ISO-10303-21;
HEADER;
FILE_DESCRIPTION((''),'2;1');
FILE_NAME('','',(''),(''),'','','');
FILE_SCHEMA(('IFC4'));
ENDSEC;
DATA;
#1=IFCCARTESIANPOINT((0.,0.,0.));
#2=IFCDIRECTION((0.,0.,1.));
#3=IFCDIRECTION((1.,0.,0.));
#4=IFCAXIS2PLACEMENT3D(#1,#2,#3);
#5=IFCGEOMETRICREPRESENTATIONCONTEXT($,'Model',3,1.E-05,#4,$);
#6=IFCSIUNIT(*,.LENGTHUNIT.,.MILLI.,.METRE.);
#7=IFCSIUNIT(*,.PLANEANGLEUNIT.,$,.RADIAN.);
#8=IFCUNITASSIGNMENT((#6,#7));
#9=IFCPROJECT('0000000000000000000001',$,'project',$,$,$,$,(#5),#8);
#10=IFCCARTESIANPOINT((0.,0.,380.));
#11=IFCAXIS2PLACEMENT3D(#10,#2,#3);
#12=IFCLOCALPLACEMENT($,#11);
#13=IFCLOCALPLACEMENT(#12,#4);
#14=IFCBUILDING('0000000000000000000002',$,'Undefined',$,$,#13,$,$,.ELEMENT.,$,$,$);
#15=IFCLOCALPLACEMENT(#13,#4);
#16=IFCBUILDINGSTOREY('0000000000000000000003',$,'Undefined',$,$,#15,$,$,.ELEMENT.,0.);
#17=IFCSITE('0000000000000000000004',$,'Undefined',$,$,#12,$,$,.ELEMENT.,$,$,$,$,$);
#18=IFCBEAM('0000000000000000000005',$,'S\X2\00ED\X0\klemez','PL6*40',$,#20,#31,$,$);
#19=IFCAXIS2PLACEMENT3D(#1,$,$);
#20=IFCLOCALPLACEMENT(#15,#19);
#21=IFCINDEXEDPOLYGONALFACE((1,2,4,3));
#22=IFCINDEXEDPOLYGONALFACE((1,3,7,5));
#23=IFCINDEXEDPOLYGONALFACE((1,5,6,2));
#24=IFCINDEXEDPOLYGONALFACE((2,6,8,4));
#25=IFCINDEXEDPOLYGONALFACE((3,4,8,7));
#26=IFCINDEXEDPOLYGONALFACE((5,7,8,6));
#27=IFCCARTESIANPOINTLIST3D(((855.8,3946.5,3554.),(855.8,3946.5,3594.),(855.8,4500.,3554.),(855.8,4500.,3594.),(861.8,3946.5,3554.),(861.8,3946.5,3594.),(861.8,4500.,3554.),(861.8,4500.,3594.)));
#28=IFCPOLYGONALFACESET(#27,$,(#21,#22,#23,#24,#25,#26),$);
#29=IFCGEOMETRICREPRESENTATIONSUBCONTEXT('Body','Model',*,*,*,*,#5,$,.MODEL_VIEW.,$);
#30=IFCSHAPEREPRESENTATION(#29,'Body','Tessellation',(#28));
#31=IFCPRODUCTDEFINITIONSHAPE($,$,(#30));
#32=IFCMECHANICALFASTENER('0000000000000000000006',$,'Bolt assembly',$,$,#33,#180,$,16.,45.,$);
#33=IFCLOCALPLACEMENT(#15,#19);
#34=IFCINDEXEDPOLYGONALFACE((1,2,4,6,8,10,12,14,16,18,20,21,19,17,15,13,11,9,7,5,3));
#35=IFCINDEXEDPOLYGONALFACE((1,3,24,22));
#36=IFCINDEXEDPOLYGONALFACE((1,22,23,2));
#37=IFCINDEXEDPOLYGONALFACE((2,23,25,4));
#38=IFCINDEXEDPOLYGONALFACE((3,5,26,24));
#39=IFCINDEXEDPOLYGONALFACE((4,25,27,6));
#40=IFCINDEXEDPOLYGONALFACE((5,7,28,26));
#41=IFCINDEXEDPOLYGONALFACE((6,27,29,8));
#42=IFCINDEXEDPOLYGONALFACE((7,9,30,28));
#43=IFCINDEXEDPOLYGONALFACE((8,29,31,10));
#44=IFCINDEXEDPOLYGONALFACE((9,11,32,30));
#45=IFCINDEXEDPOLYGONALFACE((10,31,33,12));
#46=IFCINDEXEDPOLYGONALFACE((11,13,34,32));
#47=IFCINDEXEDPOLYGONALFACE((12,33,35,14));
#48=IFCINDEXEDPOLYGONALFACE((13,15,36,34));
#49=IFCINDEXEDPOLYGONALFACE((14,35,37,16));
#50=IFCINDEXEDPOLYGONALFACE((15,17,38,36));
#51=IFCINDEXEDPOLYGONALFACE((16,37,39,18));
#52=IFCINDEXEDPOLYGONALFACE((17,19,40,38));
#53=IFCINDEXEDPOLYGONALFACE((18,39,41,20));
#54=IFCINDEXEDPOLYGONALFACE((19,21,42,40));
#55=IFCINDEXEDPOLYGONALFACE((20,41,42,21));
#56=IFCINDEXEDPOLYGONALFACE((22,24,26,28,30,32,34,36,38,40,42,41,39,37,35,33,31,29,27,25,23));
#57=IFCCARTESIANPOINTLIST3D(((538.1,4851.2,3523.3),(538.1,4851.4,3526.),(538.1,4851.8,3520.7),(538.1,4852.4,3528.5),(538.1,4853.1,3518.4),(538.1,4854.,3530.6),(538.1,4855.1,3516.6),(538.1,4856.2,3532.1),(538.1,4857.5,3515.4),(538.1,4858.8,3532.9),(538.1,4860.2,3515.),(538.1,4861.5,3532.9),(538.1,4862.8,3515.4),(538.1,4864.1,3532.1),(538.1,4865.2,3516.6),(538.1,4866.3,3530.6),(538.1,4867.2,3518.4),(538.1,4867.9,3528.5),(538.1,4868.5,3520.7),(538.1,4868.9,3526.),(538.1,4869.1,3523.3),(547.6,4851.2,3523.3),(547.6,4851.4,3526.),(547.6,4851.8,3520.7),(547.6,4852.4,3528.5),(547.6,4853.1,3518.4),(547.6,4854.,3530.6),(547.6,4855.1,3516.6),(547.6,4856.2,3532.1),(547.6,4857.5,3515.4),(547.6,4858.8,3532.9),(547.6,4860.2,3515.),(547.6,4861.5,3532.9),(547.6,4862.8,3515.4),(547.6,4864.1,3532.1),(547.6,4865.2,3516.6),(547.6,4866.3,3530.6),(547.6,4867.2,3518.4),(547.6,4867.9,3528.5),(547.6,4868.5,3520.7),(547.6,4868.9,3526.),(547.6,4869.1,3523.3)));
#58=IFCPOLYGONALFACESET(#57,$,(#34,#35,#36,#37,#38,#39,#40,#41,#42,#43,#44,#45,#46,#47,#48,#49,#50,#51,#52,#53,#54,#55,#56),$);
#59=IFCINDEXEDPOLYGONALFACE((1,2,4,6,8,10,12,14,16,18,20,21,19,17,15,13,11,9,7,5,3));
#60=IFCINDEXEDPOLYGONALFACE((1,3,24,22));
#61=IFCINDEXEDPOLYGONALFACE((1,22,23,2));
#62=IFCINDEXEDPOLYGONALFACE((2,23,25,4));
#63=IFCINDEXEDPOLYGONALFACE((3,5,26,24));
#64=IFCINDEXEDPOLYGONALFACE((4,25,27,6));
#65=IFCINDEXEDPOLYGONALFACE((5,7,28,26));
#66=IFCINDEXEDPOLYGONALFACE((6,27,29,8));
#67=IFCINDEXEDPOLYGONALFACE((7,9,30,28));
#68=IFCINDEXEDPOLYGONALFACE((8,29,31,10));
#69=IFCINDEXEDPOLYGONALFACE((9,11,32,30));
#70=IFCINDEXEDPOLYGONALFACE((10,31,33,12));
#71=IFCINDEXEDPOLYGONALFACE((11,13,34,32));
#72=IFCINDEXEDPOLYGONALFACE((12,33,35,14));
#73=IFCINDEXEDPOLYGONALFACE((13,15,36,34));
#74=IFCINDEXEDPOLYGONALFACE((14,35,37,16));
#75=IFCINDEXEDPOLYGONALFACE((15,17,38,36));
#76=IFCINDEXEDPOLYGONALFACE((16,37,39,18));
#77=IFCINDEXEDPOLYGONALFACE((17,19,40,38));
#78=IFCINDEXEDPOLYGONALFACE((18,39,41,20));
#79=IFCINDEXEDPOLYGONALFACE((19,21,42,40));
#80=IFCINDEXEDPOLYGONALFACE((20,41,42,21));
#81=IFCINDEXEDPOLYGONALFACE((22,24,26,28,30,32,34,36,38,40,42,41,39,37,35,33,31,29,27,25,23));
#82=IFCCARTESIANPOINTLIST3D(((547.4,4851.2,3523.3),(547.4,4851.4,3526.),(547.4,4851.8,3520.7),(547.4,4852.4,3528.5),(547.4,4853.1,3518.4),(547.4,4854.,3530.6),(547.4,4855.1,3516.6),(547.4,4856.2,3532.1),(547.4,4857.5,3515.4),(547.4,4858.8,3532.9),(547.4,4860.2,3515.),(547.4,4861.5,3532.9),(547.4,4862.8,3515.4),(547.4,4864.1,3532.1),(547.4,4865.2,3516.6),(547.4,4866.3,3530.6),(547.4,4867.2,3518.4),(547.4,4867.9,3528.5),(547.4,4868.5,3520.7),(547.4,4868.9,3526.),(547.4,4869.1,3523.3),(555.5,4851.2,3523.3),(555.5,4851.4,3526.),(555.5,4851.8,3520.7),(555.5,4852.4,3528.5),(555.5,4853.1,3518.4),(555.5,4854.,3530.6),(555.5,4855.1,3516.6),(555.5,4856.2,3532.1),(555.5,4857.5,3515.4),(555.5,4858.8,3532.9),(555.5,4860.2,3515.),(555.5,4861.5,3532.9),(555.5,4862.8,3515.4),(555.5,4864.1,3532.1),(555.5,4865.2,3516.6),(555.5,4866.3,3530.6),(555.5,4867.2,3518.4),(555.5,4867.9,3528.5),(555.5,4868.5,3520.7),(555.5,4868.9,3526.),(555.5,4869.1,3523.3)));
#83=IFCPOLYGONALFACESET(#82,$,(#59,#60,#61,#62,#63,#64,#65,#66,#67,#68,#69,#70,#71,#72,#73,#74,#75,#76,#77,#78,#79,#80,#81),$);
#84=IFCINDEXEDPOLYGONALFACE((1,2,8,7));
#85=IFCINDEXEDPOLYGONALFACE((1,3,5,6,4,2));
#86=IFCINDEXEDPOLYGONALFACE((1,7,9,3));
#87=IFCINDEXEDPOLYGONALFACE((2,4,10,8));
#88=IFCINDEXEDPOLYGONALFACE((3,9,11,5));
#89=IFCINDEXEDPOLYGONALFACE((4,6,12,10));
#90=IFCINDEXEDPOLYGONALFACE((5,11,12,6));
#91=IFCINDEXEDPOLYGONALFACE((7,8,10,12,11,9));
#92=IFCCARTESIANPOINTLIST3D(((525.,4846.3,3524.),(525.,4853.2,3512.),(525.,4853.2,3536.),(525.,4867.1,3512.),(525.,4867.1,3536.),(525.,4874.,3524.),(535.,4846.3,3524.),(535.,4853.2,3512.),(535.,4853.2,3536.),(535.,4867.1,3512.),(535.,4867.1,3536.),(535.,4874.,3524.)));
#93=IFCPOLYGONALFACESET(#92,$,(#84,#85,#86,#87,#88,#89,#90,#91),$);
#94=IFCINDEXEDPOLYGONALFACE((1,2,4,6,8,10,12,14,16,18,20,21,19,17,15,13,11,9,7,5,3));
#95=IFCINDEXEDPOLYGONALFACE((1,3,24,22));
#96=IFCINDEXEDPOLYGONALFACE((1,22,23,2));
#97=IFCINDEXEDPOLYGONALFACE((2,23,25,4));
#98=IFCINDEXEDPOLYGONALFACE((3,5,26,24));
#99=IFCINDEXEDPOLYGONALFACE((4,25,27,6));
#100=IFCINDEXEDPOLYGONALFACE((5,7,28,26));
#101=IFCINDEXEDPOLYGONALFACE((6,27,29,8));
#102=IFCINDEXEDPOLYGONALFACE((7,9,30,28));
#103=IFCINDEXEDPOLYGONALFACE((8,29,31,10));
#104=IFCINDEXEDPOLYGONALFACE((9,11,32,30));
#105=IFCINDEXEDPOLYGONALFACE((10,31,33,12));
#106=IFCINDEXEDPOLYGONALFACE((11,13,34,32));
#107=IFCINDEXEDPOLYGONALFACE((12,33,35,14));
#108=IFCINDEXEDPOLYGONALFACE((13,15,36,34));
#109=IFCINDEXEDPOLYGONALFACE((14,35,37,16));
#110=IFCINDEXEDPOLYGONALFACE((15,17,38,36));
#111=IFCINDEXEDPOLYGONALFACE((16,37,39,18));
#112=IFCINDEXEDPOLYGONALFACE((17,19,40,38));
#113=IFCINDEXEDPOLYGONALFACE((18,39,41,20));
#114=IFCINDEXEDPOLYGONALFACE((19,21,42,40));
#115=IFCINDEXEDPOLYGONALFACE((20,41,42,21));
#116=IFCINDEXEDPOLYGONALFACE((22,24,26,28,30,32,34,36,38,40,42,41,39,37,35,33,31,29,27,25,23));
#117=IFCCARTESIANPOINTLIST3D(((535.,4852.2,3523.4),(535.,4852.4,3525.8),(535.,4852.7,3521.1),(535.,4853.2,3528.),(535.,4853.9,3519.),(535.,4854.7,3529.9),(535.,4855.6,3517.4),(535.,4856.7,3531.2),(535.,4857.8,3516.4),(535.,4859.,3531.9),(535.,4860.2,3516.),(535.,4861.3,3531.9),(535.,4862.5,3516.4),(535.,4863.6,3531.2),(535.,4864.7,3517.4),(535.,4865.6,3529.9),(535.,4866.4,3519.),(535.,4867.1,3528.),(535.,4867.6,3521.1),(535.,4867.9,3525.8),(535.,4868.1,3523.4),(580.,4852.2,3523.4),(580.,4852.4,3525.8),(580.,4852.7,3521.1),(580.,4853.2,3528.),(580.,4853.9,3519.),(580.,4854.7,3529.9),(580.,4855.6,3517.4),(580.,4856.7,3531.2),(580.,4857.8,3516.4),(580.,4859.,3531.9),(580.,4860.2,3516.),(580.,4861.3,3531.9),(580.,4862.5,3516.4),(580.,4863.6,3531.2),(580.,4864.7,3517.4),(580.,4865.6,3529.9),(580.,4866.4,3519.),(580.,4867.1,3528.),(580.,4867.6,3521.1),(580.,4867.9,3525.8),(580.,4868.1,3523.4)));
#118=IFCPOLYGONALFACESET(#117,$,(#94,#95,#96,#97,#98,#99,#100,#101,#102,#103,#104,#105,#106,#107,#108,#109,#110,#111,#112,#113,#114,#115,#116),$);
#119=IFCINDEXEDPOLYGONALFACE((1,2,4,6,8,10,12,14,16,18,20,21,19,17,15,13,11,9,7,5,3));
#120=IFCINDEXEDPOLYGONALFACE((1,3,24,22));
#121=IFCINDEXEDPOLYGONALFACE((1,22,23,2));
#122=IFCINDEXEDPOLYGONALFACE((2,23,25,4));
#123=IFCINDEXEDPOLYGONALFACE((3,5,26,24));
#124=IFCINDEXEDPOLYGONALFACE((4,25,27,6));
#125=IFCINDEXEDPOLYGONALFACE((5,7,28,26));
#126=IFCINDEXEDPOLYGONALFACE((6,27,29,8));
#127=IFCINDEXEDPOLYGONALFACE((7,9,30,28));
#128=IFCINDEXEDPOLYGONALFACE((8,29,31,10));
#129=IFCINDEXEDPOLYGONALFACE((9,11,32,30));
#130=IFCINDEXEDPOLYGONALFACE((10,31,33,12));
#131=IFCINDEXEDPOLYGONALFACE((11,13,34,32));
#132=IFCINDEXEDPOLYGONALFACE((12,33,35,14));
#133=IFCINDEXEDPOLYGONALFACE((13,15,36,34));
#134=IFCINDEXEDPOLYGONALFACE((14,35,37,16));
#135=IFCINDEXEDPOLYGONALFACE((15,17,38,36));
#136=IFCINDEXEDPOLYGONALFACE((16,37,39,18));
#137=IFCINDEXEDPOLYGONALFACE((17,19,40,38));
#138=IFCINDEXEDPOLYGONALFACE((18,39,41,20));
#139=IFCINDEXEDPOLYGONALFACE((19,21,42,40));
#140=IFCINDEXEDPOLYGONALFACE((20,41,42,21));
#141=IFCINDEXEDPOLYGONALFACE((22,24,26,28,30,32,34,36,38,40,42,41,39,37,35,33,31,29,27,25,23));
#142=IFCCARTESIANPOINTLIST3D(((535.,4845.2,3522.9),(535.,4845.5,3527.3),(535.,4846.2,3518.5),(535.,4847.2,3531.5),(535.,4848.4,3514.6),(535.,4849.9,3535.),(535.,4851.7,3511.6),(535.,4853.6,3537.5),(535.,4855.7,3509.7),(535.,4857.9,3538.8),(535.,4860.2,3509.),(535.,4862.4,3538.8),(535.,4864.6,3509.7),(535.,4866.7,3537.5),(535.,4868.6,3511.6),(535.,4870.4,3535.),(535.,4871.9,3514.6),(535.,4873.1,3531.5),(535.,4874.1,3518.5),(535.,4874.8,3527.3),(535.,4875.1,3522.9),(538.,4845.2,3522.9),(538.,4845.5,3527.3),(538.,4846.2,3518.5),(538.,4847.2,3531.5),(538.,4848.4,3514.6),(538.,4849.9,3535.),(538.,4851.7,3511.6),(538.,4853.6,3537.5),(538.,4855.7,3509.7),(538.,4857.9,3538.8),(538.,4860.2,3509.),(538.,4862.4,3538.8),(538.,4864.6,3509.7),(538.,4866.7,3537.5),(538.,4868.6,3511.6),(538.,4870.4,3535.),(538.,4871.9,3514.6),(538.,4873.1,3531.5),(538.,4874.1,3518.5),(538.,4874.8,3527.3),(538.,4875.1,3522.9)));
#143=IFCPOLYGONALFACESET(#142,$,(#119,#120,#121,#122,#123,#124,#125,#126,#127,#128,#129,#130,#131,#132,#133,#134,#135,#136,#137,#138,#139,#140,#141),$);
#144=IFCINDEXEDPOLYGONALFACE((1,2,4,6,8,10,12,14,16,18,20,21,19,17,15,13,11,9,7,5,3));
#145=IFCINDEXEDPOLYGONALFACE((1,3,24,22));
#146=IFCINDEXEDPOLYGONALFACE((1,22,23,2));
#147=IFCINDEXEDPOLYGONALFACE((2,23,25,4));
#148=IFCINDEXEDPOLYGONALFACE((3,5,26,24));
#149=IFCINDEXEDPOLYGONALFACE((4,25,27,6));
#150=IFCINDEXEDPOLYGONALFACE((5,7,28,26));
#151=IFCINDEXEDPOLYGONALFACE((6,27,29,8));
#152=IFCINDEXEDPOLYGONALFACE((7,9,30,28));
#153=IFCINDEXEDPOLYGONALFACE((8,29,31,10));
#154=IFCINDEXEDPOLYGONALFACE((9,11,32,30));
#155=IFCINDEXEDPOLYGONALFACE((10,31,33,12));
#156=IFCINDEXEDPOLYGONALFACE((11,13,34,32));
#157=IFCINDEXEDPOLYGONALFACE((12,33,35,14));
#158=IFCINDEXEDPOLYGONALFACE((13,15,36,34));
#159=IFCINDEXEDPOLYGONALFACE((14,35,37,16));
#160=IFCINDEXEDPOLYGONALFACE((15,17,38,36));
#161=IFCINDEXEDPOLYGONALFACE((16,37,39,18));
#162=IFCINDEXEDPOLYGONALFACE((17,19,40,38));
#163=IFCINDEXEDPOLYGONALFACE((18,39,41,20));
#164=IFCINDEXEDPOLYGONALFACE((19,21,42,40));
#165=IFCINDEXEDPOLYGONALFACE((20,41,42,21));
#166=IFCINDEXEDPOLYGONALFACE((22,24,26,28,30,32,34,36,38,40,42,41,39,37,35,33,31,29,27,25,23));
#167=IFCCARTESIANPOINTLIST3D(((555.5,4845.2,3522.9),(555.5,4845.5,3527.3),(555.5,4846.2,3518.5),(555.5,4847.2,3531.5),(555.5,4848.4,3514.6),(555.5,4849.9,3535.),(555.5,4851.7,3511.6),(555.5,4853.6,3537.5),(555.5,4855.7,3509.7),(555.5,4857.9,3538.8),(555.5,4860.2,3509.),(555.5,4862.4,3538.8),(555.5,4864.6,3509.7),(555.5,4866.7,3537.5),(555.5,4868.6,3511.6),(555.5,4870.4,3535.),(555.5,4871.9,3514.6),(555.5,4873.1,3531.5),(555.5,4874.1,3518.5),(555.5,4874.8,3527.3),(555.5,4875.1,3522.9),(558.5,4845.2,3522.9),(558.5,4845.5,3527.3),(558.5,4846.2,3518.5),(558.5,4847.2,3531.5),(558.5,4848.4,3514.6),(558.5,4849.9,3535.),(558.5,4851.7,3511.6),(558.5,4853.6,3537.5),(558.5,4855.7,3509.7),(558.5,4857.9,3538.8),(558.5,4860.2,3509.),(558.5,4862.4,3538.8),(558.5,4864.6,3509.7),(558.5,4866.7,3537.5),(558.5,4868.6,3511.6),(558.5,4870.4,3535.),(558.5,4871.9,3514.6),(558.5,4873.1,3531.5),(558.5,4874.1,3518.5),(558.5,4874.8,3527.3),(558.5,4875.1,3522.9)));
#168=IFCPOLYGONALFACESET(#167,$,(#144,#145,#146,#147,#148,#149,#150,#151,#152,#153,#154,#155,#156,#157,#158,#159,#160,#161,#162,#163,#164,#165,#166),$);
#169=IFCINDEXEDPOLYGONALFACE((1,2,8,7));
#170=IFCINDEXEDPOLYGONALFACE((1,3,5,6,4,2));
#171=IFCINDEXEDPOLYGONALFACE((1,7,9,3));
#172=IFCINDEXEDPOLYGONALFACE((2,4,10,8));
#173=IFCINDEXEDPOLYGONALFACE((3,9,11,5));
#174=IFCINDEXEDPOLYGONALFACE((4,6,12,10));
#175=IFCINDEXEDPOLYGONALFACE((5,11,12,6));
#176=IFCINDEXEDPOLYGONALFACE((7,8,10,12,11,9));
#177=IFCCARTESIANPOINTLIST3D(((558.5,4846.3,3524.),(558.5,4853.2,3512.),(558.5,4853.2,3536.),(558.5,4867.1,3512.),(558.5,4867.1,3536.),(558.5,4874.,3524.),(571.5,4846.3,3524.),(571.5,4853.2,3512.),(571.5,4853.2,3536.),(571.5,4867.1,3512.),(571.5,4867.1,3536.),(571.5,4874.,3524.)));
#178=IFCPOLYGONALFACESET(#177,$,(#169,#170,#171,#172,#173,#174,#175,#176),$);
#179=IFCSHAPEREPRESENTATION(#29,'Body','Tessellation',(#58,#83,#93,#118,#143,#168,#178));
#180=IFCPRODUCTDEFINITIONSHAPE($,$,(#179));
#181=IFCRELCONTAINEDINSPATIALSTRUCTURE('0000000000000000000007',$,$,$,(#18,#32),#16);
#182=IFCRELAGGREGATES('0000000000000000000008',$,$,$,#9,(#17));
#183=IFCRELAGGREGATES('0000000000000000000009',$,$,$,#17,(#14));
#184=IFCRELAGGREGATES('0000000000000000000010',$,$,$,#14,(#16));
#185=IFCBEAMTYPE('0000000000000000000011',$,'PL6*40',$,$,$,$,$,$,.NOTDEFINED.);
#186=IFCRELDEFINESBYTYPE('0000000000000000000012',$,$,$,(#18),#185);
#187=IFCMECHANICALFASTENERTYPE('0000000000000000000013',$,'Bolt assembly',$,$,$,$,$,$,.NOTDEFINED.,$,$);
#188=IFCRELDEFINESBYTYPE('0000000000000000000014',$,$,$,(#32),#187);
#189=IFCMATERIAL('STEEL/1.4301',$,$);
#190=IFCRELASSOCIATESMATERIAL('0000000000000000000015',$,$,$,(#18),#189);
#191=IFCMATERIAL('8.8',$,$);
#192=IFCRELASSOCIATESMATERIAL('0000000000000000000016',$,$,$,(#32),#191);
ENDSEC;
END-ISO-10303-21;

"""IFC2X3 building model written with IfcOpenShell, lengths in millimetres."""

from ifc_helpers import new_model, si_unit, frame, origin_with_axes, origin_2d_with_axis, place, context, subcontext, project, spatial, polyline, rectangle, circle, outline, extrude, source, transform, mapped, material, type_object, element, save


model = new_model("IFC2X3")

# Units and contexts
model_context = context("Model", 3, precision=1e-05, world=origin_with_axes())
body_context = subcontext(model_context, "Body", "Model", "MODEL_VIEW")
ifc_project = project(units=[si_unit("LENGTHUNIT", "METRE", prefix="MILLI"), si_unit("PLANEANGLEUNIT", "RADIAN")], contexts=[model_context])

# Site, building, storey
site_placement = place(None, frame((0.0, 0.0, 380.0), z_axis=(0.0, 0.0, 1.0), x_axis=(1.0, 0.0, 0.0)))
site = spatial("IfcSite", under=ifc_project, at=site_placement, Name="Undefined", CompositionType="ELEMENT")
building_placement = place(site_placement, origin_with_axes())
building = spatial("IfcBuilding", under=site, at=building_placement, Name="Undefined", CompositionType="ELEMENT")
storey_placement = place(building_placement, origin_with_axes())
storey = spatial("IfcBuildingStorey", under=building, at=storey_placement, Name="Undefined", CompositionType="ELEMENT", Elevation=0.0)

# Beam
ifc_material_1 = material(Name="STEEL/1.4301")
beam_type_1 = type_object("IfcBeamType", Name="PL6*40", PredefinedType="NOTDEFINED")
for number, where, z_axis, x_axis, name in (
    (1, (858.8, 4500.0, 3574.0), (0.0, 0.0, 1.0), (0.0, -1.0, 0.0), "Síklemez"),
):
    element("IfcBeam", number, at=place(storey_placement, frame(where, z_axis=z_axis, x_axis=x_axis)), inside=storey, type_object=beam_type_1, material=ifc_material_1, Name=name, Description="PL6*40", context=body_context, shape_type="SweptSolid", body=[
        extrude(rectangle(XDim=6.0, YDim=40.0, at=origin_2d_with_axis()), frame((553.5, 0.0, 0.0), z_axis=(-1.0, 0.0, 0.0), x_axis=(0.0, -1.0, 0.0)), (0.0, 0.0, 1.0), 553.5),
    ])

# Mechanical fastener
ifc_material_2 = material(Name="8.8")
mechanical_fastener_type = type_object("IfcMechanicalFastenerType", Name="Bolt assembly")
shared_shape_1 = source(origin_with_axes(), body_context, "Body", "SweptSolid", [
    extrude(circle(Radius=9.0, at=origin_2d_with_axis()), frame((0.0, -9.4, 0.0), z_axis=(0.0, 1.0, 0.0), x_axis=(1.0, 0.0, 0.0)), (0.0, 0.0, 1.0), 9.5),
    extrude(circle(Radius=9.0, at=origin_2d_with_axis()), frame((0.0, -0.1, 0.0), z_axis=(0.0, 1.0, 0.0), x_axis=(1.0, 0.0, 0.0)), (0.0, 0.0, 1.0), 8.1),
    extrude(outline(polyline([(12.0, -6.9), (12.0, 6.9), (0.0, 13.9), (-12.0, 6.9), (-12.0, -6.9), (0.0, -13.9), (12.0, -6.9)])), frame((0.0, -22.5, 0.0), z_axis=(0.0, 1.0, 0.0), x_axis=(1.0, 0.0, 0.0)), (0.0, 0.0, 1.0), 10.0),
    extrude(circle(Radius=8.0, at=origin_2d_with_axis()), frame((0.0, -12.5, 0.0), z_axis=(0.0, 1.0, 0.0), x_axis=(1.0, 0.0, 0.0)), (0.0, 0.0, 1.0), 45.0),
    extrude(circle(Radius=15.0, at=origin_2d_with_axis()), frame((0.0, -12.5, 0.0), z_axis=(0.0, 1.0, 0.0), x_axis=(1.0, 0.0, 0.0)), (0.0, 0.0, 1.0), 3.0),
    extrude(circle(Radius=15.0, at=origin_2d_with_axis()), frame((0.0, 8.0, 0.0), z_axis=(0.0, 1.0, 0.0), x_axis=(1.0, 0.0, 0.0)), (0.0, 0.0, 1.0), 3.0),
    extrude(outline(polyline([(12.0, -6.9), (12.0, 6.9), (0.0, 13.9), (-12.0, 6.9), (-12.0, -6.9), (0.0, -13.9), (12.0, -6.9)])), frame((0.0, 11.0, 0.0), z_axis=(0.0, 1.0, 0.0), x_axis=(1.0, 0.0, 0.0)), (0.0, 0.0, 1.0), 13.0),
])
mechanical_fastener_1_placement = place(storey_placement, frame((547.5, 4897.7, 3594.0), z_axis=(0.0, -1.0, 0.0), x_axis=(0.0, 0.0, -1.0)))
element("IfcMechanicalFastener", 2, at=mechanical_fastener_1_placement, inside=storey, type_object=mechanical_fastener_type, material=ifc_material_2, Name="Bolt assembly", NominalDiameter=16.0, NominalLength=45.0, context=body_context, shape_type="MappedRepresentation", body=[
    mapped(shared_shape_1, transform((70.0, 0.0, 37.5))),
])

save(model, "model.ifc")
